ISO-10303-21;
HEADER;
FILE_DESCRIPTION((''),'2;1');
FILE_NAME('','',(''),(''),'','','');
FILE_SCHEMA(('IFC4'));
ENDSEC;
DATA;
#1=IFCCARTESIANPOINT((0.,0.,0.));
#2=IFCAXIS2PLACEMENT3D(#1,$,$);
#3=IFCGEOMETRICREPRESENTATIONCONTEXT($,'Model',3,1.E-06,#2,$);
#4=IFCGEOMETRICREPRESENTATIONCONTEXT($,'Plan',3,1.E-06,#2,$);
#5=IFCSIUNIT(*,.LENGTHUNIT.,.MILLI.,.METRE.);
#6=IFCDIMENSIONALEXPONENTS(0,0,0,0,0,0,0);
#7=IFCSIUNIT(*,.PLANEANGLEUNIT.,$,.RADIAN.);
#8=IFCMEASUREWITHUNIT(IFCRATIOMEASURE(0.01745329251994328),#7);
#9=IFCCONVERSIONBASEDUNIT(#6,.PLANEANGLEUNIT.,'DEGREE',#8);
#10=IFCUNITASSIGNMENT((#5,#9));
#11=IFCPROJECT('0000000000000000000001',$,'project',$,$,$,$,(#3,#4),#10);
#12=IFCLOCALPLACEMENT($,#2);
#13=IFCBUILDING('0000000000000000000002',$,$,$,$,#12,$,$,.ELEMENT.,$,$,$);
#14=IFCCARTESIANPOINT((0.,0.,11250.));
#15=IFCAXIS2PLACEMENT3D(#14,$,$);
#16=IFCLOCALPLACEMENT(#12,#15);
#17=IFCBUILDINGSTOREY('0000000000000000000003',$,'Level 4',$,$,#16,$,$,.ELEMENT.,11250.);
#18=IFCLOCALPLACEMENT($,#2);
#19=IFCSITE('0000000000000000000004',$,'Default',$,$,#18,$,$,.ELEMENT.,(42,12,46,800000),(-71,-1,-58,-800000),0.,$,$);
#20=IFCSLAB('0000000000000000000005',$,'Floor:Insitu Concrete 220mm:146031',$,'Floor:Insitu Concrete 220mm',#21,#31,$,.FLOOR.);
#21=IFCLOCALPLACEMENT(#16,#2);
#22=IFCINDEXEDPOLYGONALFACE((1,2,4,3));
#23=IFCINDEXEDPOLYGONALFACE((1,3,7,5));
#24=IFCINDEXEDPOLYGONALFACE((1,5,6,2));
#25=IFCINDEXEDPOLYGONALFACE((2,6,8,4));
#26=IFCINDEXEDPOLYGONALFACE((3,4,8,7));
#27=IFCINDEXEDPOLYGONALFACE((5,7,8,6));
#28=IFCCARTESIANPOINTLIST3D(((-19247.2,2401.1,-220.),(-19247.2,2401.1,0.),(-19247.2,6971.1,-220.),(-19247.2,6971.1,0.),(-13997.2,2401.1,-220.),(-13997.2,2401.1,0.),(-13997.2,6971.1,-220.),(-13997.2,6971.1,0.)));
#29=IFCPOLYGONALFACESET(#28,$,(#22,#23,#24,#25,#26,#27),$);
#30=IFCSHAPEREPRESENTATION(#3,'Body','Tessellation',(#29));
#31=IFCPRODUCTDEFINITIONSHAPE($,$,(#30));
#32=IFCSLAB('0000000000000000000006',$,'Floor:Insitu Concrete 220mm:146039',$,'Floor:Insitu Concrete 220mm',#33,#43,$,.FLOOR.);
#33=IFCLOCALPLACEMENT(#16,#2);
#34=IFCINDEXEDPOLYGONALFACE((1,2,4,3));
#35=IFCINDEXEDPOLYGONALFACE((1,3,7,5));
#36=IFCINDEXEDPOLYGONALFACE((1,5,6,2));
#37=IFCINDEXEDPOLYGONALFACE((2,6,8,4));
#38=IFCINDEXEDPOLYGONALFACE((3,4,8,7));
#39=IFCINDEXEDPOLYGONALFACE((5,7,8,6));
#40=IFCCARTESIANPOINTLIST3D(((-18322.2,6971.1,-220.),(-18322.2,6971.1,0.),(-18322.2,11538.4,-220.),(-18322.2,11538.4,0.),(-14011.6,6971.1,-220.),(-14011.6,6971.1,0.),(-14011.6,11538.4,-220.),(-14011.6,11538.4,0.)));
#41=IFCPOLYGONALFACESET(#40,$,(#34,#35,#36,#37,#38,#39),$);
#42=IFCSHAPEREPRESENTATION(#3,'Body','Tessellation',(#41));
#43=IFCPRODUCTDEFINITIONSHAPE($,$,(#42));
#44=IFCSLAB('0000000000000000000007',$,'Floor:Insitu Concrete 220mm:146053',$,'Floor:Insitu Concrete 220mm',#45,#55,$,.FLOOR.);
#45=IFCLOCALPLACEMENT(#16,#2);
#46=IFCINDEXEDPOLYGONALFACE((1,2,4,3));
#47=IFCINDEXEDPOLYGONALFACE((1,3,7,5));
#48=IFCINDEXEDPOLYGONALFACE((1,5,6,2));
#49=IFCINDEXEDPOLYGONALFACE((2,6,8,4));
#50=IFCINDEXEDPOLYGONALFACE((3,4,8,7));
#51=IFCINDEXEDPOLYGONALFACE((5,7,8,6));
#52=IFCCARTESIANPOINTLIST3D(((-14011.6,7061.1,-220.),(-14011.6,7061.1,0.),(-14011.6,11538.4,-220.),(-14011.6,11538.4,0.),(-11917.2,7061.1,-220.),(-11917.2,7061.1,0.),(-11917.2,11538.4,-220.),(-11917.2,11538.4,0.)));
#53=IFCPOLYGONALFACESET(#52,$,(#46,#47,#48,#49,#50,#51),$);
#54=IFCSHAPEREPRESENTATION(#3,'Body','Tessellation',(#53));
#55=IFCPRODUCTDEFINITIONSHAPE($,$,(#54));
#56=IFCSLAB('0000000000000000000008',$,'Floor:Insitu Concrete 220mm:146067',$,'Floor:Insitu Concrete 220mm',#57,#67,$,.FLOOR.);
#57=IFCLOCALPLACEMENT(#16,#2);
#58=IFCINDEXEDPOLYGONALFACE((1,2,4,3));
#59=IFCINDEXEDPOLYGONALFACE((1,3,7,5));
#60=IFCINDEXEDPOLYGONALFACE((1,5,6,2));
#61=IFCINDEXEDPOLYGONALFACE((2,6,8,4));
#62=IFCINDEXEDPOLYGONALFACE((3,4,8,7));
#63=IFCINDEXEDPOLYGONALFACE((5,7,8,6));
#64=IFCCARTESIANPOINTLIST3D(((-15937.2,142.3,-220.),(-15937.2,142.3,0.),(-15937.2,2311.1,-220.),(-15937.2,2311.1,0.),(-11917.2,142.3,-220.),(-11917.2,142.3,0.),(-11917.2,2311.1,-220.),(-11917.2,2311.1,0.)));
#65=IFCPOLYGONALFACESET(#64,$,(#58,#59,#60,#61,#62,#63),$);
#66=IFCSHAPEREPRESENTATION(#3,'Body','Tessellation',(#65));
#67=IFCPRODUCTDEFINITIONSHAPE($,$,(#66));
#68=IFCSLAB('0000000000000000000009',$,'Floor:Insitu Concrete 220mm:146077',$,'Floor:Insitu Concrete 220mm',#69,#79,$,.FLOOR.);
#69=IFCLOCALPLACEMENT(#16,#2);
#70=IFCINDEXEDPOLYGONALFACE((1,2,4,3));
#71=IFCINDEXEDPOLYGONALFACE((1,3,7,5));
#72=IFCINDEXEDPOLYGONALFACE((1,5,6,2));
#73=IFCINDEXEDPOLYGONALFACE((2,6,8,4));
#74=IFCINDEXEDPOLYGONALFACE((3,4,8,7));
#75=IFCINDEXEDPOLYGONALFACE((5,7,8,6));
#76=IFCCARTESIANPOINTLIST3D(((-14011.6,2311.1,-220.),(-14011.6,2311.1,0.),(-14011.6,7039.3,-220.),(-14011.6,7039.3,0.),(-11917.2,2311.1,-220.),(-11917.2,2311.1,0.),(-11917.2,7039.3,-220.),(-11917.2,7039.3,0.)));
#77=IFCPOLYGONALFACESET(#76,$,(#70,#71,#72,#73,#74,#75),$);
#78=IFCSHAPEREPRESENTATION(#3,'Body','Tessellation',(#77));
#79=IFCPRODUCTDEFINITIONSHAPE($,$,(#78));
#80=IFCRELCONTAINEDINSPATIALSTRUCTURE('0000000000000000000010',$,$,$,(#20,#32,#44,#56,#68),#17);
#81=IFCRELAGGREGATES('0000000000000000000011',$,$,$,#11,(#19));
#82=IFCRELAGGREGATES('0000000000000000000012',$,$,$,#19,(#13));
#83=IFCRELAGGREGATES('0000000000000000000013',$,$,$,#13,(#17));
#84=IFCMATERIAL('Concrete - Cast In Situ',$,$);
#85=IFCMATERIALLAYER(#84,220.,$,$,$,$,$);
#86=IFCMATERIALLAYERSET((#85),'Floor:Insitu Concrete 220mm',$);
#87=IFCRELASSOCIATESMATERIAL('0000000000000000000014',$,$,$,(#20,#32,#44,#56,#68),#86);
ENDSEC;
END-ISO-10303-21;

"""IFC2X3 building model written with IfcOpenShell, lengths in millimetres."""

from ifc_helpers import new_model, entity, si_unit, converted_unit, frame, frame_2d, origin, place, context, project, spatial, rectangle, extrude, material, layer, layer_set, layer_usage, element, save


model = new_model("IFC2X3")

# Units and contexts
model_context = context("Model", 3, precision=1e-06, world=origin())
plan_context = context("Plan", 3, precision=1e-06, world=origin())
ifc_project = project(units=[si_unit("LENGTHUNIT", "METRE", prefix="MILLI"), converted_unit("PLANEANGLEUNIT", "DEGREE", entity("IfcRatioMeasure", 0.01745329251994328), si_unit("PLANEANGLEUNIT", "RADIAN"), dimensions=[0, 0, 0, 0, 0, 0, 0])], contexts=[model_context, plan_context])

# Site, building, storey
site_placement = place(None, origin())
site = spatial("IfcSite", under=ifc_project, at=site_placement, Name="Default", CompositionType="ELEMENT", RefLatitude=(42, 12, 46, 800000), RefLongitude=(-71, -1, -58, -800000), RefElevation=0.0)
building_placement = place(None, origin())
building = spatial("IfcBuilding", under=site, at=building_placement, CompositionType="ELEMENT")
storey_placement = place(building_placement, frame((0.0, 0.0, 11250.0)))
storey = spatial("IfcBuildingStorey", under=building, at=storey_placement, Name="Level 4", CompositionType="ELEMENT", Elevation=11250.0)

# Slabs
ifc_material = material(Name="Concrete - Cast In Situ")
ifc_layer = layer(ifc_material, 220.0)
ifc_layer_set = layer_set([ifc_layer], Name="Floor:Insitu Concrete 220mm")
ifc_layer_usage_1 = layer_usage(ifc_layer_set, "AXIS3", "POSITIVE", 0.0)
slab_1_placement = place(storey_placement, frame((-19247.2, 2401.1, -220.0)))
element("IfcSlab", 1, at=slab_1_placement, inside=storey, material=ifc_layer_usage_1, Name="Floor:Insitu Concrete 220mm:146031", ObjectType="Floor:Insitu Concrete 220mm", PredefinedType="FLOOR", context=model_context, shape_type="SweptSolid", body=[
    extrude(rectangle(XDim=4570.0, YDim=5250.0, at=frame_2d((16622.2, 4686.1), x_axis=(0.0, -1.0))), frame((19247.2, -2401.1, 220.0), z_axis=(0.0, 0.0, -1.0), x_axis=(-1.0, 0.0, 0.0)), (0.0, 0.0, 1.0), 220.0),
])
ifc_layer_usage_2 = layer_usage(ifc_layer_set, "AXIS3", "POSITIVE", 0.0)
slab_2_placement = place(storey_placement, frame((-18322.2, 6971.1, -220.0)))
element("IfcSlab", 2, at=slab_2_placement, inside=storey, material=ifc_layer_usage_2, Name="Floor:Insitu Concrete 220mm:146039", ObjectType="Floor:Insitu Concrete 220mm", PredefinedType="FLOOR", context=model_context, shape_type="SweptSolid", body=[
    extrude(rectangle(XDim=4567.3, YDim=4310.6, at=frame_2d((16166.9, 9254.7), x_axis=(0.0, -1.0))), frame((18322.2, -6971.1, 220.0), z_axis=(0.0, 0.0, -1.0), x_axis=(-1.0, 0.0, 0.0)), (0.0, 0.0, 1.0), 220.0),
])
ifc_layer_usage_3 = layer_usage(ifc_layer_set, "AXIS3", "POSITIVE", 0.0)
slab_3_placement = place(storey_placement, frame((-14011.6, 7061.1, -220.0)))
element("IfcSlab", 3, at=slab_3_placement, inside=storey, material=ifc_layer_usage_3, Name="Floor:Insitu Concrete 220mm:146053", ObjectType="Floor:Insitu Concrete 220mm", PredefinedType="FLOOR", context=model_context, shape_type="SweptSolid", body=[
    extrude(rectangle(XDim=4477.3, YDim=2094.4, at=frame_2d((12964.4, 9299.7), x_axis=(0.0, -1.0))), frame((14011.6, -7061.1, 220.0), z_axis=(0.0, 0.0, -1.0), x_axis=(-1.0, 0.0, 0.0)), (0.0, 0.0, 1.0), 220.0),
])
ifc_layer_usage_4 = layer_usage(ifc_layer_set, "AXIS3", "POSITIVE", 0.0)
slab_4_placement = place(storey_placement, frame((-15937.2, 142.3, -220.0)))
element("IfcSlab", 4, at=slab_4_placement, inside=storey, material=ifc_layer_usage_4, Name="Floor:Insitu Concrete 220mm:146067", ObjectType="Floor:Insitu Concrete 220mm", PredefinedType="FLOOR", context=model_context, shape_type="SweptSolid", body=[
    extrude(rectangle(XDim=2168.8, YDim=4020.0, at=frame_2d((13927.2, 1226.7), x_axis=(0.0, -1.0))), frame((15937.2, -142.3, 220.0), z_axis=(0.0, 0.0, -1.0), x_axis=(-1.0, 0.0, 0.0)), (0.0, 0.0, 1.0), 220.0),
])
ifc_layer_usage_5 = layer_usage(ifc_layer_set, "AXIS3", "POSITIVE", 0.0)
slab_5_placement = place(storey_placement, frame((-14011.6, 2311.1, -220.0)))
element("IfcSlab", 5, at=slab_5_placement, inside=storey, material=ifc_layer_usage_5, Name="Floor:Insitu Concrete 220mm:146077", ObjectType="Floor:Insitu Concrete 220mm", PredefinedType="FLOOR", context=model_context, shape_type="SweptSolid", body=[
    extrude(rectangle(XDim=4728.2, YDim=2094.4, at=frame_2d((12964.4, 4675.2), x_axis=(0.0, -1.0))), frame((14011.6, -2311.1, 220.0), z_axis=(0.0, 0.0, -1.0), x_axis=(-1.0, 0.0, 0.0)), (0.0, 0.0, 1.0), 220.0),
])

save(model, "model.ifc")
